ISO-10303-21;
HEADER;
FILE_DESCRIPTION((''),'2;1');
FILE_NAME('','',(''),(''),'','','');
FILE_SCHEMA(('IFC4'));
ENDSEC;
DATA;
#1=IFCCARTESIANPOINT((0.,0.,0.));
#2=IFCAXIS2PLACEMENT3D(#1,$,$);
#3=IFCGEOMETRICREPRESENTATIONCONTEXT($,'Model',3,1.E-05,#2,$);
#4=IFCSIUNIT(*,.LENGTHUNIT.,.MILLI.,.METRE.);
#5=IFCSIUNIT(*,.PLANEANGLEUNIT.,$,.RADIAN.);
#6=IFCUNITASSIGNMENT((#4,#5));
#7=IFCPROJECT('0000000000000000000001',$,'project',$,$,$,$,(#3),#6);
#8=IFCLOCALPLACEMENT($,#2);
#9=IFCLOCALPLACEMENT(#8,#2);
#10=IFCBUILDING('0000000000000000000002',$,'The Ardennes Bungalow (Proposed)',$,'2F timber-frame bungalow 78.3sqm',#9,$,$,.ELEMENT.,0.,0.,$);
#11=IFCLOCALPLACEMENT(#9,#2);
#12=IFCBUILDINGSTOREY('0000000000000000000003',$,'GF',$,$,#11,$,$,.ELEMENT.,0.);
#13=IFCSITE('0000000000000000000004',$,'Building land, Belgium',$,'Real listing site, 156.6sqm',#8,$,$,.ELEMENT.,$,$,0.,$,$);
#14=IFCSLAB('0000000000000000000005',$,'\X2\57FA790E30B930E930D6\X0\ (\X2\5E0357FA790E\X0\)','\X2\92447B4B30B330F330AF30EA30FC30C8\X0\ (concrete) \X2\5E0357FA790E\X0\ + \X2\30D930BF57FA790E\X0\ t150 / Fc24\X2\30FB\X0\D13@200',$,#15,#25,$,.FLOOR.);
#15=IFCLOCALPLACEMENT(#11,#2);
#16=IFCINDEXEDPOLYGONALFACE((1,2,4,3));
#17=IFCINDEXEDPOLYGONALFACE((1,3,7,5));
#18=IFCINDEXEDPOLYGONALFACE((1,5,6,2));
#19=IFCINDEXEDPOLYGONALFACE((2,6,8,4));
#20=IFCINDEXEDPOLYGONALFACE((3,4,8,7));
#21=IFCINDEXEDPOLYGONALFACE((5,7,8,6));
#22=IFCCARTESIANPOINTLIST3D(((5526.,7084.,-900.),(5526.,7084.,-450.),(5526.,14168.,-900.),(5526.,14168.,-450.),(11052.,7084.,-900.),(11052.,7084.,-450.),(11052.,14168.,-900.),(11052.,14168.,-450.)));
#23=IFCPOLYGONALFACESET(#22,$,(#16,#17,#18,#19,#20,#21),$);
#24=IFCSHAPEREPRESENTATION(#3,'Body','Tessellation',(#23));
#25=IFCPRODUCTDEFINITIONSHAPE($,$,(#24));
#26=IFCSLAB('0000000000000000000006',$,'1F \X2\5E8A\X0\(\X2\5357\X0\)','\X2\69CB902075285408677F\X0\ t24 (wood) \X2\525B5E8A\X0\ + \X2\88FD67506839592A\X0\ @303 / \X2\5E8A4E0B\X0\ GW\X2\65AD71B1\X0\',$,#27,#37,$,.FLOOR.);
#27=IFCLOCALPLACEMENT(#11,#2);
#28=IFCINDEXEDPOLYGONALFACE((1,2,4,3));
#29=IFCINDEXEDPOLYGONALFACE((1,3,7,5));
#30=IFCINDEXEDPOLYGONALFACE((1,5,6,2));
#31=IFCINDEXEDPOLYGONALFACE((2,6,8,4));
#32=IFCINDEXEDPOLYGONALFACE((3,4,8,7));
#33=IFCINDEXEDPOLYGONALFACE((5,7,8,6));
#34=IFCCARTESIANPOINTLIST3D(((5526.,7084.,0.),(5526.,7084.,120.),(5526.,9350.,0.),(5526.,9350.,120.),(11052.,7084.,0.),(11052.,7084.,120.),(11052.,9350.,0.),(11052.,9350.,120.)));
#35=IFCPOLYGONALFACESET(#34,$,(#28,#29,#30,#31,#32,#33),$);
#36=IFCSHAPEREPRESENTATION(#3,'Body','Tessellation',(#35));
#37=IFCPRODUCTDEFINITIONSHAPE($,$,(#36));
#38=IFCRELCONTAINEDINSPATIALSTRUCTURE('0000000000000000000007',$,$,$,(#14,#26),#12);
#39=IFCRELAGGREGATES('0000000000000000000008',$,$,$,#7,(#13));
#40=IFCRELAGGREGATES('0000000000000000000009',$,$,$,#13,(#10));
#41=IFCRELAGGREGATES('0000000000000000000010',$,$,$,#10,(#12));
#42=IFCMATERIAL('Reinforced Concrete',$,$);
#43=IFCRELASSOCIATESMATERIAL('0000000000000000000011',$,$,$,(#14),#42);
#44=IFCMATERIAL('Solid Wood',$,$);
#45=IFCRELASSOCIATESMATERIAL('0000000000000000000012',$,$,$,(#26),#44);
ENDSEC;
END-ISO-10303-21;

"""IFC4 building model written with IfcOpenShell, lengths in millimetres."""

from ifc_helpers import new_model, si_unit, frame, frame_2d, origin, place, context, project, spatial, rectangle, extrude, material, element, save


model = new_model("IFC4")

# Units and contexts
model_context = context("Model", 3, precision=1e-05, world=origin())
ifc_project = project(units=[si_unit("LENGTHUNIT", "METRE", prefix="MILLI"), si_unit("PLANEANGLEUNIT", "RADIAN")], contexts=[model_context])

# Site, building, storey
site_placement = place(None, origin())
site = spatial("IfcSite", under=ifc_project, at=site_placement, Name="Building land, Belgium", ObjectType="Real listing site, 156.6sqm", CompositionType="ELEMENT", RefElevation=0.0)
building_placement = place(site_placement, origin())
building = spatial("IfcBuilding", under=site, at=building_placement, Name="The Ardennes Bungalow (Proposed)", ObjectType="2F timber-frame bungalow 78.3sqm", CompositionType="ELEMENT", ElevationOfRefHeight=0.0, ElevationOfTerrain=0.0)
storey_placement = place(building_placement, origin())
storey = spatial("IfcBuildingStorey", under=building, at=storey_placement, Name="GF", CompositionType="ELEMENT", Elevation=0.0)

# Slabs
ifc_material_1 = material(Name="Reinforced Concrete")
slab_1_placement = place(storey_placement, frame((2763.0, 3542.0, -450.0)))
element("IfcSlab", 1, at=slab_1_placement, inside=storey, material=ifc_material_1, Name="基礎スラブ (布基礎)", Description="鉄筋コンクリート (concrete) 布基礎 + ベタ基礎 t150 / Fc24・D13@200", PredefinedType="FLOOR", context=model_context, shape_type="SweptSolid", body=[
    extrude(rectangle(XDim=5526.0, YDim=7084.0, at=frame_2d((2763.0, 3542.0))), frame((2763.0, 3542.0, -450.0)), (0.0, 0.0, 1.0), 450.0),
])
ifc_material_2 = material(Name="Solid Wood")
slab_2_placement = place(storey_placement, frame((2763.0, 3542.0, 0.0)))
element("IfcSlab", 2, at=slab_2_placement, inside=storey, material=ifc_material_2, Name="1F 床(南)", Description="構造用合板 t24 (wood) 剛床 + 製材根太 @303 / 床下 GW断熱", PredefinedType="FLOOR", context=model_context, shape_type="SweptSolid", body=[
    extrude(rectangle(XDim=5526.0, YDim=2266.0, at=frame_2d((2763.0, 1133.0))), frame((2763.0, 3542.0, 0.0)), (0.0, 0.0, 1.0), 120.0),
])

save(model, "model.ifc")
